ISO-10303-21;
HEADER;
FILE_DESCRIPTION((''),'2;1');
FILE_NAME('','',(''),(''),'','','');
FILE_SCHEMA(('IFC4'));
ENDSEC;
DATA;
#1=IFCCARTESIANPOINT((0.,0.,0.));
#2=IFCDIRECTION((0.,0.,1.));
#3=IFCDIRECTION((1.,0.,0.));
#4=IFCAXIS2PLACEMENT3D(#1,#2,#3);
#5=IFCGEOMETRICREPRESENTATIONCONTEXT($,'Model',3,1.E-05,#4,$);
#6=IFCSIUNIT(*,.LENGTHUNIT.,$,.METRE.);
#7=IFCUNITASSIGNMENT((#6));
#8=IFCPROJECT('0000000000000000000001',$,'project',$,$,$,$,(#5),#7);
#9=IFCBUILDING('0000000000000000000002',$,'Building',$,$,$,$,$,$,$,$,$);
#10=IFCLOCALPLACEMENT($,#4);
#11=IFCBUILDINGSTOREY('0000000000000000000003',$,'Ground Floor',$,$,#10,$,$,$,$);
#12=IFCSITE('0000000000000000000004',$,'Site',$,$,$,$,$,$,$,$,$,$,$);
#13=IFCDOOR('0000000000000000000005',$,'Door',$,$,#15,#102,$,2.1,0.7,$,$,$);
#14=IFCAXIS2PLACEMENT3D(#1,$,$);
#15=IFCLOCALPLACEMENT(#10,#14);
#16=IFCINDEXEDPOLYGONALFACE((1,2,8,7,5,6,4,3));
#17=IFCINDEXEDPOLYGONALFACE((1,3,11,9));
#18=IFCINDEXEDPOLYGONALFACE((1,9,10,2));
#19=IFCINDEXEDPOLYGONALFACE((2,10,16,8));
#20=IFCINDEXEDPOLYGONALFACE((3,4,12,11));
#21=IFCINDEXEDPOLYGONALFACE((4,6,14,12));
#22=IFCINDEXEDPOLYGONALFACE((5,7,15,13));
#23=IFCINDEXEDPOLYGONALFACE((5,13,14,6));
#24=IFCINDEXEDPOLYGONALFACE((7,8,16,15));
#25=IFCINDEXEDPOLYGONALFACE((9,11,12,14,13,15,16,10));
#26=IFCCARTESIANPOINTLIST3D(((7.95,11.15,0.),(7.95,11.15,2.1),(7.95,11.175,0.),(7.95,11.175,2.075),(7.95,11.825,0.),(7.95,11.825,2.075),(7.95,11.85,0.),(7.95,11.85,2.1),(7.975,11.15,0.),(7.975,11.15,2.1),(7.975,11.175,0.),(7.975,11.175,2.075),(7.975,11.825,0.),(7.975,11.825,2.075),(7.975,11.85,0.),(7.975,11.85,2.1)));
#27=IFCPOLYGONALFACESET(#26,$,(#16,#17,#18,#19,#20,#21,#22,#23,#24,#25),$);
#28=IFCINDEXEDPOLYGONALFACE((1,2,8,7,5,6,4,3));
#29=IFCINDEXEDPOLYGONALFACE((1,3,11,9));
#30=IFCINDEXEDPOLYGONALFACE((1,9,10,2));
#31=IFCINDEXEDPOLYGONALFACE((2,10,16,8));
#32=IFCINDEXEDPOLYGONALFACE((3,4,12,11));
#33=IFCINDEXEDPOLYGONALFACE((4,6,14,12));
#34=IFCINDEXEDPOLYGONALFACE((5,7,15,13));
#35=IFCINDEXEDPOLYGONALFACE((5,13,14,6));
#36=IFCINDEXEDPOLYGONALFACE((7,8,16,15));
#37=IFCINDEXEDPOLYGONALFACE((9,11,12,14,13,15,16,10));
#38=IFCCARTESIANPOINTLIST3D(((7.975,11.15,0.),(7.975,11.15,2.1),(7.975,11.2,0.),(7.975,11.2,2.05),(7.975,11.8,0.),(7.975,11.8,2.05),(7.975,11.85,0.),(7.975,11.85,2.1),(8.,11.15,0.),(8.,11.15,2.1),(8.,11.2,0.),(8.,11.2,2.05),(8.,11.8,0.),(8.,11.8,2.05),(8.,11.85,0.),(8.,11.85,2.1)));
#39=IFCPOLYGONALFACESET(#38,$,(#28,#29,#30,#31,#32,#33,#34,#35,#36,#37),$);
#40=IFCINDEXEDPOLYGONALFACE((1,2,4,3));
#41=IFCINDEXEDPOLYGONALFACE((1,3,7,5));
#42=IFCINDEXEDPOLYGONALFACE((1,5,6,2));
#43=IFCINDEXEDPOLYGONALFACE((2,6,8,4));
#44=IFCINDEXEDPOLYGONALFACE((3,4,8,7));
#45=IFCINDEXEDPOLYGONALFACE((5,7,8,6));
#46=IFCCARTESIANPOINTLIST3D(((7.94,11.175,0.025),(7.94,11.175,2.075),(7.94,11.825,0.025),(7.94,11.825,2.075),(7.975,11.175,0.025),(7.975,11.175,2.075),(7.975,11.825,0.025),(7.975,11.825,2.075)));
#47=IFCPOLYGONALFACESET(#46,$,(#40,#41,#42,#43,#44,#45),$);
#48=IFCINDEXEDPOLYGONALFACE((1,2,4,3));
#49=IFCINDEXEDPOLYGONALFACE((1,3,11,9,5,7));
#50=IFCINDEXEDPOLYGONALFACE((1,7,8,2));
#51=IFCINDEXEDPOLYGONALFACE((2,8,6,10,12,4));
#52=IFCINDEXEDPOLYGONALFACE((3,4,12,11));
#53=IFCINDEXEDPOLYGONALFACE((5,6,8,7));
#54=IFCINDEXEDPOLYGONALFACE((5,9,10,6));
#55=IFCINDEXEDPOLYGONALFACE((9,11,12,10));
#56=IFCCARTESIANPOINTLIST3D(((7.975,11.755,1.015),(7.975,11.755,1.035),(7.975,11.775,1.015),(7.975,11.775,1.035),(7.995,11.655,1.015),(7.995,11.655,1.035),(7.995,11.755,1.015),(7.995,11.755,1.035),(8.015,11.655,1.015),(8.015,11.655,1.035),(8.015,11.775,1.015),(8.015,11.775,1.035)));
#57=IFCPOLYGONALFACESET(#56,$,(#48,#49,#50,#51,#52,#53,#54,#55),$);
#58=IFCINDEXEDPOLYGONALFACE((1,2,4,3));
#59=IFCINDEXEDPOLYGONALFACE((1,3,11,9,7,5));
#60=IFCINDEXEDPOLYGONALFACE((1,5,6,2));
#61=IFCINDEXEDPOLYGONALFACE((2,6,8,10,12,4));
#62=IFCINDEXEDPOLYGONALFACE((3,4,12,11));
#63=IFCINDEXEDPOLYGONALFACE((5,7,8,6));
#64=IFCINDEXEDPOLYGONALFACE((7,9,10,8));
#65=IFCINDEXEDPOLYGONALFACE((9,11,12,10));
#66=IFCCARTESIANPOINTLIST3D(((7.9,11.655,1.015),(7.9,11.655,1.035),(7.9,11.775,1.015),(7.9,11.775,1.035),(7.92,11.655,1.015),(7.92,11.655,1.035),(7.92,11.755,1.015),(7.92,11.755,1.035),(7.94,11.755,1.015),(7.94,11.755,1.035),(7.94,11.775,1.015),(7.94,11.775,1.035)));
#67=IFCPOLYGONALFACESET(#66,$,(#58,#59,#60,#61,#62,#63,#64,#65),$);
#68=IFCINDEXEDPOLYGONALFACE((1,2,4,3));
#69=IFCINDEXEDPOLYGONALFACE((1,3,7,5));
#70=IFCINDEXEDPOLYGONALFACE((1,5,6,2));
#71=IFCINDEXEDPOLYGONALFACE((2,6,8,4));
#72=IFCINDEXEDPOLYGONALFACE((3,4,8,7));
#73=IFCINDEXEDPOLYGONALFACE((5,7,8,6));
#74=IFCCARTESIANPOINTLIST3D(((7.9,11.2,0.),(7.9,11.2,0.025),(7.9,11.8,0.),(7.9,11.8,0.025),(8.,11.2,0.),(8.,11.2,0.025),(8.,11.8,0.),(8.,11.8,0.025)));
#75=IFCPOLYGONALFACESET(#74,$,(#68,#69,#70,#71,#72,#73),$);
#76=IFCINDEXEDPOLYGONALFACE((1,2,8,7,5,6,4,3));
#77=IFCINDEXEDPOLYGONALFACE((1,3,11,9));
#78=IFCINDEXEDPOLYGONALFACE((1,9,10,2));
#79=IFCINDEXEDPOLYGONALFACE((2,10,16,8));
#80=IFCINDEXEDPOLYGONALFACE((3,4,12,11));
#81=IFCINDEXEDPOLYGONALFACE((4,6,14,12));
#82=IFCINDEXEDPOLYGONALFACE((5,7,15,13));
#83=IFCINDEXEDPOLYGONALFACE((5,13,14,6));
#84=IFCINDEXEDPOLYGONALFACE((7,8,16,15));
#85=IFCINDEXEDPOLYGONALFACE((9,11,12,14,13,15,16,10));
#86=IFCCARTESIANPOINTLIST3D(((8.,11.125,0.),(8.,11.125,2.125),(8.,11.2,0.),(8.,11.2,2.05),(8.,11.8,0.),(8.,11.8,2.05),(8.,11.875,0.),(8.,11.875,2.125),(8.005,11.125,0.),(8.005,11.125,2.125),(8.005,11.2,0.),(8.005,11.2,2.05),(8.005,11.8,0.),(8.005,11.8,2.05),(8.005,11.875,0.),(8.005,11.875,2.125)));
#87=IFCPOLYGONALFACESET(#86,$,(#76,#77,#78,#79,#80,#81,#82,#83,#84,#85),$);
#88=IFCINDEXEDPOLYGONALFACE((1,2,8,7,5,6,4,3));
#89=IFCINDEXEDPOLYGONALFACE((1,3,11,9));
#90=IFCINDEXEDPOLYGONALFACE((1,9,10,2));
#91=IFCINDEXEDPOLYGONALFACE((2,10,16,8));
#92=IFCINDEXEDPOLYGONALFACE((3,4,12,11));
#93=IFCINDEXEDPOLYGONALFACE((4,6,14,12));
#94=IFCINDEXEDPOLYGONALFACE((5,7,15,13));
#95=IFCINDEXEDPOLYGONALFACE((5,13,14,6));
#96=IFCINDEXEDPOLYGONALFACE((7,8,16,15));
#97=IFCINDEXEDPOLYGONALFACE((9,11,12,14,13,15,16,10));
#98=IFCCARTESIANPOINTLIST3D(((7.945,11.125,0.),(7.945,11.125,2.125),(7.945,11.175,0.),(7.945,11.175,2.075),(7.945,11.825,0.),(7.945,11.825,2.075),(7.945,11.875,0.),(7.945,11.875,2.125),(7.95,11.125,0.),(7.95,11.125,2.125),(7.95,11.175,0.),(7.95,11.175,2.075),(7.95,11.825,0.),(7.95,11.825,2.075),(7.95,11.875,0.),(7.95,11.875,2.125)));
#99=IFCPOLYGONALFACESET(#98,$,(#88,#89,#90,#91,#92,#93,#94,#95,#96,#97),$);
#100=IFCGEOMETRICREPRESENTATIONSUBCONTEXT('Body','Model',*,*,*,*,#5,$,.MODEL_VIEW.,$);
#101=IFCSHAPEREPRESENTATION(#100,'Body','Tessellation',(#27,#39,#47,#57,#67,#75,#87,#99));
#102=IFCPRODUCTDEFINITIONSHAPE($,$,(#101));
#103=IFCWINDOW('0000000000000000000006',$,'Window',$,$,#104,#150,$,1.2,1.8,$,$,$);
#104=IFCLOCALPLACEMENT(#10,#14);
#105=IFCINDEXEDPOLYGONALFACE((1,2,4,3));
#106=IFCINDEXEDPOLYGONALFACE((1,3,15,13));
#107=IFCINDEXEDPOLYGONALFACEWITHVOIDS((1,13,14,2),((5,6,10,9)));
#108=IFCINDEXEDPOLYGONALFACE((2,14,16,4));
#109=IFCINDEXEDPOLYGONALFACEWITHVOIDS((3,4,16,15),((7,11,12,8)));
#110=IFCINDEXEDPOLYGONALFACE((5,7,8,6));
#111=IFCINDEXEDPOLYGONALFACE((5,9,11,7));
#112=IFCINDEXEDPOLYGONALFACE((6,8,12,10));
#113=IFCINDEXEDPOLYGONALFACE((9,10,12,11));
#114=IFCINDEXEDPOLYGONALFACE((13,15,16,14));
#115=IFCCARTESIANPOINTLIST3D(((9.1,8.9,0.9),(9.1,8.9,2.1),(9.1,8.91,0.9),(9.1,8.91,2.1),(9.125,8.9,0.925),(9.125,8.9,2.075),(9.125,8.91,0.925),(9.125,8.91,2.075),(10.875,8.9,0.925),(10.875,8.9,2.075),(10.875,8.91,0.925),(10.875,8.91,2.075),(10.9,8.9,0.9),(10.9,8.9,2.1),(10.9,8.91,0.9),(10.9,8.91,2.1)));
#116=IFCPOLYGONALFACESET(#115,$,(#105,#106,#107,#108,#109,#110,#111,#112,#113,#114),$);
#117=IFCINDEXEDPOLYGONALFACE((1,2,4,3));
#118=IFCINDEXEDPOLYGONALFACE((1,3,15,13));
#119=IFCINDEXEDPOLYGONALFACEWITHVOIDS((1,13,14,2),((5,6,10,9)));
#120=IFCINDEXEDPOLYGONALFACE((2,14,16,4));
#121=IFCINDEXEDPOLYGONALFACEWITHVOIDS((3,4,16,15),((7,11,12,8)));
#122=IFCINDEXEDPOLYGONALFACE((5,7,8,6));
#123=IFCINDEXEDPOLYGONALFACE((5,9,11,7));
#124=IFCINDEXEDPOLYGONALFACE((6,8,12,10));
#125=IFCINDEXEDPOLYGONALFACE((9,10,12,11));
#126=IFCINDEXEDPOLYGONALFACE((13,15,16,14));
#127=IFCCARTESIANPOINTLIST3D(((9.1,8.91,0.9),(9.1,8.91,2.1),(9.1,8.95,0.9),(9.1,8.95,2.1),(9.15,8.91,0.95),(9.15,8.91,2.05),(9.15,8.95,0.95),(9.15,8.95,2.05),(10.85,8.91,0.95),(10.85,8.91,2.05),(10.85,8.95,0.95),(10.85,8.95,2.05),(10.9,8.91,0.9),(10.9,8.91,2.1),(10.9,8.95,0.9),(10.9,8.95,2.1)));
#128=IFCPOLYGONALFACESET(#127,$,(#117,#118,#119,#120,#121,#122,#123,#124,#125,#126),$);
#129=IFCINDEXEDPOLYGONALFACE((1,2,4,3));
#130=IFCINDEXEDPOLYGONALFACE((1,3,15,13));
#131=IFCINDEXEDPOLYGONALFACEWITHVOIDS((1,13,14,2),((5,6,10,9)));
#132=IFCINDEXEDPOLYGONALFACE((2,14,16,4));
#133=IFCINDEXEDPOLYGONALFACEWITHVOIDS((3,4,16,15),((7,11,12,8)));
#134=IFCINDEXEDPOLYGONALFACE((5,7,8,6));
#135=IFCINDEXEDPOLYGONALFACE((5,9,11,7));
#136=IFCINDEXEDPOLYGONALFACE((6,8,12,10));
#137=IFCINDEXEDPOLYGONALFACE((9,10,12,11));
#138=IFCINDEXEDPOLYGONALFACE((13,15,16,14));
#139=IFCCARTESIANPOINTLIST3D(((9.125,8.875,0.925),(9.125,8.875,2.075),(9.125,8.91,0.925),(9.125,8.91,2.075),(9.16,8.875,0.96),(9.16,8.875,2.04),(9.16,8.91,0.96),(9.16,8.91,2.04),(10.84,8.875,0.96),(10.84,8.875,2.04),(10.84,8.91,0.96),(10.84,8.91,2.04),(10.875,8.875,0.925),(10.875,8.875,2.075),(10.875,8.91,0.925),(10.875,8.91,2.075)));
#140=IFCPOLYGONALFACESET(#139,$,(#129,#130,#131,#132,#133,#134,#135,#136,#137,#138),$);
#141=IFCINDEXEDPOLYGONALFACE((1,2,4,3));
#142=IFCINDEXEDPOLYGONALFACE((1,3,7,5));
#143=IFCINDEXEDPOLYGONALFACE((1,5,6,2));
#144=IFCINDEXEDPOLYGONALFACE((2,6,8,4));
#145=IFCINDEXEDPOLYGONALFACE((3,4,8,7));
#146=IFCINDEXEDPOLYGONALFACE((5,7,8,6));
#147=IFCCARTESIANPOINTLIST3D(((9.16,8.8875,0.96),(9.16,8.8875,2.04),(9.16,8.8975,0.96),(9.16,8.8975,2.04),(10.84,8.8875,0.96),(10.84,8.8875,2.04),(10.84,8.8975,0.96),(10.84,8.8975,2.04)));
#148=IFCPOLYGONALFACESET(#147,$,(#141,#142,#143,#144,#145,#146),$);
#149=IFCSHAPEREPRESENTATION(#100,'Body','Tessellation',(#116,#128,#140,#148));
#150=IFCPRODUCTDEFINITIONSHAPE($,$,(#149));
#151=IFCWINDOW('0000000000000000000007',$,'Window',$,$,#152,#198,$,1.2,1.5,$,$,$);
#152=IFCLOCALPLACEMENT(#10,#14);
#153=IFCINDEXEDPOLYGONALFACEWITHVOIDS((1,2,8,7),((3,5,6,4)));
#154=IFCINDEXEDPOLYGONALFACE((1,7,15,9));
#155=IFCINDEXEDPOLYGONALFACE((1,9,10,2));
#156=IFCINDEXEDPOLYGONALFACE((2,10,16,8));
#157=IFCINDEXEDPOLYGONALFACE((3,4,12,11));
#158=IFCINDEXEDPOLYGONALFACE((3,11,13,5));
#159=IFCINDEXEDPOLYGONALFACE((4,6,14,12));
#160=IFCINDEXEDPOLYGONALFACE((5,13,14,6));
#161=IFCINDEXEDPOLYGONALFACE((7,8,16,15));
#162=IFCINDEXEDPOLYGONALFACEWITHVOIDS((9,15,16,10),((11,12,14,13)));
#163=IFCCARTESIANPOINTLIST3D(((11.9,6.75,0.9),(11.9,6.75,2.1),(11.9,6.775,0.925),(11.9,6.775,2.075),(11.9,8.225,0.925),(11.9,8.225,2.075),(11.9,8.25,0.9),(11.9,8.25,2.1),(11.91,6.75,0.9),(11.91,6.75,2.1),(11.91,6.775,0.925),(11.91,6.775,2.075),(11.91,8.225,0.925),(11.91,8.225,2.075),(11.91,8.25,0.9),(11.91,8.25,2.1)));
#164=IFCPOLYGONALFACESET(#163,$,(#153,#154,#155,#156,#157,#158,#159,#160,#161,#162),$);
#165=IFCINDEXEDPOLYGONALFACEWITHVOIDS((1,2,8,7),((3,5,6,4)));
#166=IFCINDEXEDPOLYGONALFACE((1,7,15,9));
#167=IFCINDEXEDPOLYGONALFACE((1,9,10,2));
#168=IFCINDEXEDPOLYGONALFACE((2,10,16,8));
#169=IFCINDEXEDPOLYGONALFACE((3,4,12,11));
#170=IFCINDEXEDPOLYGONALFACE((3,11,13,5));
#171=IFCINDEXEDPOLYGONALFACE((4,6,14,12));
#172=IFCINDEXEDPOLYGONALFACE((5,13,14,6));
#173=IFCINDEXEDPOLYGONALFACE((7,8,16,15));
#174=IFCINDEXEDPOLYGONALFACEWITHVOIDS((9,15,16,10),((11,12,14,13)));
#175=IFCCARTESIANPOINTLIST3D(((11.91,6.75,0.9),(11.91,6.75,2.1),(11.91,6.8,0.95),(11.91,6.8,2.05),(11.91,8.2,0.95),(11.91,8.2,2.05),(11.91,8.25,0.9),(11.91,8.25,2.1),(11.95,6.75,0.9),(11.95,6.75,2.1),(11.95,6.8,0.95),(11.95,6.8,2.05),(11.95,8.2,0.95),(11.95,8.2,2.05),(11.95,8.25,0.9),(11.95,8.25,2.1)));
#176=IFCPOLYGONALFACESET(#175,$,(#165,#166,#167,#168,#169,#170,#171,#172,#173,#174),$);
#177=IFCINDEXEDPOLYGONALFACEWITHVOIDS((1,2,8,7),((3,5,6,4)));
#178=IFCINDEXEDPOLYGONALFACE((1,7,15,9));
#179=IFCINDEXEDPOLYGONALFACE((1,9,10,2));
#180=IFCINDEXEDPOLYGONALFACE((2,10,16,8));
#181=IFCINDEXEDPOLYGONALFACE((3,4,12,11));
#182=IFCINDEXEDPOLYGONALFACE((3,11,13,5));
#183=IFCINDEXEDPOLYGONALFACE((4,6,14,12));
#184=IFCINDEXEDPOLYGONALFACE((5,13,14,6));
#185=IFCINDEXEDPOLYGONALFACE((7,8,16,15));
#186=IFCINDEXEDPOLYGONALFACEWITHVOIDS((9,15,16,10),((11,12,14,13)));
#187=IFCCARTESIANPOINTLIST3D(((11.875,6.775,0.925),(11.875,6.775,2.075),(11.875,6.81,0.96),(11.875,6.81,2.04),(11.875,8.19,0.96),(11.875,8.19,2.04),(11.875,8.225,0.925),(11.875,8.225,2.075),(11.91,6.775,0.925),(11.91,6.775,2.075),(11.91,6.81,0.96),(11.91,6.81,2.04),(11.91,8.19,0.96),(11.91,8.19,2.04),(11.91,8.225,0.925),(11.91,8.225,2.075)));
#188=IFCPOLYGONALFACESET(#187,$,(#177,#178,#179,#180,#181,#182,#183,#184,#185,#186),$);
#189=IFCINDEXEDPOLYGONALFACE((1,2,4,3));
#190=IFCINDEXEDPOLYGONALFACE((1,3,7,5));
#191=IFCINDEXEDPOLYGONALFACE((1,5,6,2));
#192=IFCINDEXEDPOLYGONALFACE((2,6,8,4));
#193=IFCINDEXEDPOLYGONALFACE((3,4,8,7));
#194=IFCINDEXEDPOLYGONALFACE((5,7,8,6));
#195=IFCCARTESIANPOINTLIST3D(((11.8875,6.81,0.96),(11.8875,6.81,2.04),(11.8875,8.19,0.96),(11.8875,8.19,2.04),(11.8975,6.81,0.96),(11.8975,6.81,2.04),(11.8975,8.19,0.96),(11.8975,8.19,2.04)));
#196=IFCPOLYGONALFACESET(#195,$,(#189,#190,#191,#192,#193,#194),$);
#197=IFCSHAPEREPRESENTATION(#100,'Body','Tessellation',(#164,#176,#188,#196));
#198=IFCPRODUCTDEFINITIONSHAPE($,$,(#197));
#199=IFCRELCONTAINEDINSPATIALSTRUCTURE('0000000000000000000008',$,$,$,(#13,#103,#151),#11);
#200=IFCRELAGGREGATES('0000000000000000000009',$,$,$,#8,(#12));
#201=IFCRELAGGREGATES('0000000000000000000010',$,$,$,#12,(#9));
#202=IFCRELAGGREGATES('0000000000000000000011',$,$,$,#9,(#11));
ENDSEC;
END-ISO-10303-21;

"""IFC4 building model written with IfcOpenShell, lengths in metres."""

from ifc_helpers import new_model, si_unit, frame, origin_with_axes, place, context, subcontext, project, spatial, line, indexed_curve, outline, extrude, element, save


model = new_model("IFC4")

# Units and contexts
model_context = context("Model", 3, precision=1e-05, world=origin_with_axes())
body_context = subcontext(model_context, "Body", "Model", "MODEL_VIEW")
ifc_project = project(units=[si_unit("LENGTHUNIT", "METRE")], contexts=[model_context])

# Site, building, storey
site = spatial("IfcSite", under=ifc_project, Name="Site")
building = spatial("IfcBuilding", under=site, Name="Building")
storey_placement = place(None, origin_with_axes())
storey = spatial("IfcBuildingStorey", under=building, at=storey_placement, Name="Ground Floor")

# Door
door_1_placement = place(storey_placement, frame((8.0, 11.15, 0.0), z_axis=(0.0, 0.0, 1.0), x_axis=(0.0, 1.0, 0.0)))
element("IfcDoor", 1, at=door_1_placement, inside=storey, Name="Door", OverallHeight=2.1, OverallWidth=0.7, context=body_context, shape_type="SweptSolid", body=[
    extrude(outline(indexed_curve([(0.0, 0.0), (0.0, 2.1), (0.7, 2.1), (0.7, 0.0), (0.675, 0.0), (0.675, 2.075), (0.025, 2.075), (0.025, 0.0)], segments=[line(1, 2, 3, 4, 5, 6, 7, 8, 1)])), frame((0.0, 0.025, 0.0), z_axis=(0.0, -1.0, 0.0), x_axis=(1.0, 0.0, 0.0)), (0.0, 0.0, -1.0), 0.025),
    extrude(outline(indexed_curve([(0.0, 0.0), (0.0, 2.1), (0.7, 2.1), (0.7, 0.0), (0.65, 0.0), (0.65, 2.05), (0.05, 2.05), (0.05, 0.0)], segments=[line(1, 2, 3, 4, 5, 6, 7, 8, 1)])), frame((0.0, 0.0, 0.0), z_axis=(0.0, -1.0, 0.0), x_axis=(1.0, 0.0, 0.0)), (0.0, 0.0, -1.0), 0.025),
    extrude(outline(indexed_curve([(0.0, 0.0), (0.65, 0.0), (0.65, 0.035), (0.0, 0.035)], segments=[line(1, 2, 3, 4, 1)])), frame((0.025, 0.025, 0.025), z_axis=(0.0, 0.0, 1.0), x_axis=(1.0, 0.0, 0.0)), (0.0, 0.0, 1.0), 2.05),
    extrude(outline(indexed_curve([(0.0, 0.0), (0.0, -0.04), (-0.12, -0.04), (-0.12, -0.02), (-0.02, -0.02), (-0.02, 0.0)], segments=[line(1, 2, 3, 4, 5, 6, 1)])), frame((0.625, 0.025, 1.015), z_axis=(0.0, 0.0, 1.0), x_axis=(1.0, 0.0, 0.0)), (0.0, 0.0, 1.0), 0.02),
    extrude(outline(indexed_curve([(0.0, 0.0), (0.0, 0.04), (-0.12, 0.04), (-0.12, 0.02), (-0.02, 0.02), (-0.02, 0.0)], segments=[line(1, 2, 3, 4, 5, 6, 1)])), frame((0.625, 0.06, 1.015), z_axis=(0.0, 0.0, 1.0), x_axis=(1.0, 0.0, 0.0)), (0.0, 0.0, 1.0), 0.02),
    extrude(outline(indexed_curve([(0.0, 0.0), (0.6, 0.0), (0.6, 0.1), (0.0, 0.1)], segments=[line(1, 2, 3, 4, 1)])), frame((0.05, 0.0, 0.0), z_axis=(0.0, 0.0, 1.0), x_axis=(1.0, 0.0, 0.0)), (0.0, 0.0, 1.0), 0.025),
    extrude(outline(indexed_curve([(0.0, 0.0), (0.0, 2.125), (0.75, 2.125), (0.75, 0.0), (0.675, 0.0), (0.675, 2.05), (0.075, 2.05), (0.075, 0.0)], segments=[line(1, 2, 3, 4, 5, 6, 7, 8, 1)])), frame((-0.025, -0.005, 0.0), z_axis=(0.0, -1.0, 0.0), x_axis=(1.0, 0.0, 0.0)), (0.0, 0.0, -1.0), 0.005),
    extrude(outline(indexed_curve([(0.0, 0.0), (0.0, 2.125), (0.75, 2.125), (0.75, 0.0), (0.7, 0.0), (0.7, 2.075), (0.05, 2.075), (0.05, 0.0)], segments=[line(1, 2, 3, 4, 5, 6, 7, 8, 1)])), frame((-0.025, 0.05, 0.0), z_axis=(0.0, -1.0, 0.0), x_axis=(1.0, 0.0, 0.0)), (0.0, 0.0, -1.0), 0.005),
])

# Windows
window_1_placement = place(storey_placement, frame((10.9, 9.0, 0.9), z_axis=(0.0, 0.0, 1.0), x_axis=(-1.0, 0.0, 0.0)))
element("IfcWindow", 2, at=window_1_placement, inside=storey, Name="Window", OverallHeight=1.2, OverallWidth=1.8, context=body_context, shape_type="SweptSolid", body=[
    extrude(outline(indexed_curve([(0.0, 0.0), (1.8, 0.0), (1.8, 1.2), (0.0, 1.2)], segments=[line(1, 2, 3, 4, 1)]), holes=[indexed_curve([(0.025, 0.025), (1.775, 0.025), (1.775, 1.175), (0.025, 1.175)], segments=[line(1, 2, 3, 4, 1)])]), frame((0.0, 0.09, 0.0), z_axis=(0.0, -1.0, 0.0), x_axis=(1.0, 0.0, 0.0)), (0.0, 0.0, -1.0), 0.01),
    extrude(outline(indexed_curve([(0.0, 0.0), (1.8, 0.0), (1.8, 1.2), (0.0, 1.2)], segments=[line(1, 2, 3, 4, 1)]), holes=[indexed_curve([(0.05, 0.05), (1.75, 0.05), (1.75, 1.15), (0.05, 1.15)], segments=[line(1, 2, 3, 4, 1)])]), frame((0.0, 0.05, 0.0), z_axis=(0.0, -1.0, 0.0), x_axis=(1.0, 0.0, 0.0)), (0.0, 0.0, -1.0), 0.04),
    extrude(outline(indexed_curve([(0.0, 0.0), (1.75, 0.0), (1.75, 1.15), (0.0, 1.15)], segments=[line(1, 2, 3, 4, 1)]), holes=[indexed_curve([(0.035, 0.035), (1.715, 0.035), (1.715, 1.115), (0.035, 1.115)], segments=[line(1, 2, 3, 4, 1)])]), frame((0.025, 0.09, 0.025), z_axis=(0.0, -1.0, 0.0), x_axis=(1.0, 0.0, 0.0)), (0.0, 0.0, -1.0), 0.035),
    extrude(outline(indexed_curve([(0.035, 0.035), (1.715, 0.035), (1.715, 1.115), (0.035, 1.115)], segments=[line(1, 2, 3, 4, 1)])), frame((0.025, 0.1025, 0.025), z_axis=(0.0, -1.0, 0.0), x_axis=(1.0, 0.0, 0.0)), (0.0, 0.0, -1.0), 0.01),
])
window_2_placement = place(storey_placement, frame((12.0, 6.75, 0.9), z_axis=(0.0, 0.0, 1.0), x_axis=(0.0, 1.0, 0.0)))
element("IfcWindow", 3, at=window_2_placement, inside=storey, Name="Window", OverallHeight=1.2, OverallWidth=1.5, context=body_context, shape_type="SweptSolid", body=[
    extrude(outline(indexed_curve([(0.0, 0.0), (1.5, 0.0), (1.5, 1.2), (0.0, 1.2)], segments=[line(1, 2, 3, 4, 1)]), holes=[indexed_curve([(0.025, 0.025), (1.475, 0.025), (1.475, 1.175), (0.025, 1.175)], segments=[line(1, 2, 3, 4, 1)])]), frame((0.0, 0.09, 0.0), z_axis=(0.0, -1.0, 0.0), x_axis=(1.0, 0.0, 0.0)), (0.0, 0.0, -1.0), 0.01),
    extrude(outline(indexed_curve([(0.0, 0.0), (1.5, 0.0), (1.5, 1.2), (0.0, 1.2)], segments=[line(1, 2, 3, 4, 1)]), holes=[indexed_curve([(0.05, 0.05), (1.45, 0.05), (1.45, 1.15), (0.05, 1.15)], segments=[line(1, 2, 3, 4, 1)])]), frame((0.0, 0.05, 0.0), z_axis=(0.0, -1.0, 0.0), x_axis=(1.0, 0.0, 0.0)), (0.0, 0.0, -1.0), 0.04),
    extrude(outline(indexed_curve([(0.0, 0.0), (1.45, 0.0), (1.45, 1.15), (0.0, 1.15)], segments=[line(1, 2, 3, 4, 1)]), holes=[indexed_curve([(0.035, 0.035), (1.415, 0.035), (1.415, 1.115), (0.035, 1.115)], segments=[line(1, 2, 3, 4, 1)])]), frame((0.025, 0.09, 0.025), z_axis=(0.0, -1.0, 0.0), x_axis=(1.0, 0.0, 0.0)), (0.0, 0.0, -1.0), 0.035),
    extrude(outline(indexed_curve([(0.035, 0.035), (1.415, 0.035), (1.415, 1.115), (0.035, 1.115)], segments=[line(1, 2, 3, 4, 1)])), frame((0.025, 0.1025, 0.025), z_axis=(0.0, -1.0, 0.0), x_axis=(1.0, 0.0, 0.0)), (0.0, 0.0, -1.0), 0.01),
])

save(model, "model.ifc")
